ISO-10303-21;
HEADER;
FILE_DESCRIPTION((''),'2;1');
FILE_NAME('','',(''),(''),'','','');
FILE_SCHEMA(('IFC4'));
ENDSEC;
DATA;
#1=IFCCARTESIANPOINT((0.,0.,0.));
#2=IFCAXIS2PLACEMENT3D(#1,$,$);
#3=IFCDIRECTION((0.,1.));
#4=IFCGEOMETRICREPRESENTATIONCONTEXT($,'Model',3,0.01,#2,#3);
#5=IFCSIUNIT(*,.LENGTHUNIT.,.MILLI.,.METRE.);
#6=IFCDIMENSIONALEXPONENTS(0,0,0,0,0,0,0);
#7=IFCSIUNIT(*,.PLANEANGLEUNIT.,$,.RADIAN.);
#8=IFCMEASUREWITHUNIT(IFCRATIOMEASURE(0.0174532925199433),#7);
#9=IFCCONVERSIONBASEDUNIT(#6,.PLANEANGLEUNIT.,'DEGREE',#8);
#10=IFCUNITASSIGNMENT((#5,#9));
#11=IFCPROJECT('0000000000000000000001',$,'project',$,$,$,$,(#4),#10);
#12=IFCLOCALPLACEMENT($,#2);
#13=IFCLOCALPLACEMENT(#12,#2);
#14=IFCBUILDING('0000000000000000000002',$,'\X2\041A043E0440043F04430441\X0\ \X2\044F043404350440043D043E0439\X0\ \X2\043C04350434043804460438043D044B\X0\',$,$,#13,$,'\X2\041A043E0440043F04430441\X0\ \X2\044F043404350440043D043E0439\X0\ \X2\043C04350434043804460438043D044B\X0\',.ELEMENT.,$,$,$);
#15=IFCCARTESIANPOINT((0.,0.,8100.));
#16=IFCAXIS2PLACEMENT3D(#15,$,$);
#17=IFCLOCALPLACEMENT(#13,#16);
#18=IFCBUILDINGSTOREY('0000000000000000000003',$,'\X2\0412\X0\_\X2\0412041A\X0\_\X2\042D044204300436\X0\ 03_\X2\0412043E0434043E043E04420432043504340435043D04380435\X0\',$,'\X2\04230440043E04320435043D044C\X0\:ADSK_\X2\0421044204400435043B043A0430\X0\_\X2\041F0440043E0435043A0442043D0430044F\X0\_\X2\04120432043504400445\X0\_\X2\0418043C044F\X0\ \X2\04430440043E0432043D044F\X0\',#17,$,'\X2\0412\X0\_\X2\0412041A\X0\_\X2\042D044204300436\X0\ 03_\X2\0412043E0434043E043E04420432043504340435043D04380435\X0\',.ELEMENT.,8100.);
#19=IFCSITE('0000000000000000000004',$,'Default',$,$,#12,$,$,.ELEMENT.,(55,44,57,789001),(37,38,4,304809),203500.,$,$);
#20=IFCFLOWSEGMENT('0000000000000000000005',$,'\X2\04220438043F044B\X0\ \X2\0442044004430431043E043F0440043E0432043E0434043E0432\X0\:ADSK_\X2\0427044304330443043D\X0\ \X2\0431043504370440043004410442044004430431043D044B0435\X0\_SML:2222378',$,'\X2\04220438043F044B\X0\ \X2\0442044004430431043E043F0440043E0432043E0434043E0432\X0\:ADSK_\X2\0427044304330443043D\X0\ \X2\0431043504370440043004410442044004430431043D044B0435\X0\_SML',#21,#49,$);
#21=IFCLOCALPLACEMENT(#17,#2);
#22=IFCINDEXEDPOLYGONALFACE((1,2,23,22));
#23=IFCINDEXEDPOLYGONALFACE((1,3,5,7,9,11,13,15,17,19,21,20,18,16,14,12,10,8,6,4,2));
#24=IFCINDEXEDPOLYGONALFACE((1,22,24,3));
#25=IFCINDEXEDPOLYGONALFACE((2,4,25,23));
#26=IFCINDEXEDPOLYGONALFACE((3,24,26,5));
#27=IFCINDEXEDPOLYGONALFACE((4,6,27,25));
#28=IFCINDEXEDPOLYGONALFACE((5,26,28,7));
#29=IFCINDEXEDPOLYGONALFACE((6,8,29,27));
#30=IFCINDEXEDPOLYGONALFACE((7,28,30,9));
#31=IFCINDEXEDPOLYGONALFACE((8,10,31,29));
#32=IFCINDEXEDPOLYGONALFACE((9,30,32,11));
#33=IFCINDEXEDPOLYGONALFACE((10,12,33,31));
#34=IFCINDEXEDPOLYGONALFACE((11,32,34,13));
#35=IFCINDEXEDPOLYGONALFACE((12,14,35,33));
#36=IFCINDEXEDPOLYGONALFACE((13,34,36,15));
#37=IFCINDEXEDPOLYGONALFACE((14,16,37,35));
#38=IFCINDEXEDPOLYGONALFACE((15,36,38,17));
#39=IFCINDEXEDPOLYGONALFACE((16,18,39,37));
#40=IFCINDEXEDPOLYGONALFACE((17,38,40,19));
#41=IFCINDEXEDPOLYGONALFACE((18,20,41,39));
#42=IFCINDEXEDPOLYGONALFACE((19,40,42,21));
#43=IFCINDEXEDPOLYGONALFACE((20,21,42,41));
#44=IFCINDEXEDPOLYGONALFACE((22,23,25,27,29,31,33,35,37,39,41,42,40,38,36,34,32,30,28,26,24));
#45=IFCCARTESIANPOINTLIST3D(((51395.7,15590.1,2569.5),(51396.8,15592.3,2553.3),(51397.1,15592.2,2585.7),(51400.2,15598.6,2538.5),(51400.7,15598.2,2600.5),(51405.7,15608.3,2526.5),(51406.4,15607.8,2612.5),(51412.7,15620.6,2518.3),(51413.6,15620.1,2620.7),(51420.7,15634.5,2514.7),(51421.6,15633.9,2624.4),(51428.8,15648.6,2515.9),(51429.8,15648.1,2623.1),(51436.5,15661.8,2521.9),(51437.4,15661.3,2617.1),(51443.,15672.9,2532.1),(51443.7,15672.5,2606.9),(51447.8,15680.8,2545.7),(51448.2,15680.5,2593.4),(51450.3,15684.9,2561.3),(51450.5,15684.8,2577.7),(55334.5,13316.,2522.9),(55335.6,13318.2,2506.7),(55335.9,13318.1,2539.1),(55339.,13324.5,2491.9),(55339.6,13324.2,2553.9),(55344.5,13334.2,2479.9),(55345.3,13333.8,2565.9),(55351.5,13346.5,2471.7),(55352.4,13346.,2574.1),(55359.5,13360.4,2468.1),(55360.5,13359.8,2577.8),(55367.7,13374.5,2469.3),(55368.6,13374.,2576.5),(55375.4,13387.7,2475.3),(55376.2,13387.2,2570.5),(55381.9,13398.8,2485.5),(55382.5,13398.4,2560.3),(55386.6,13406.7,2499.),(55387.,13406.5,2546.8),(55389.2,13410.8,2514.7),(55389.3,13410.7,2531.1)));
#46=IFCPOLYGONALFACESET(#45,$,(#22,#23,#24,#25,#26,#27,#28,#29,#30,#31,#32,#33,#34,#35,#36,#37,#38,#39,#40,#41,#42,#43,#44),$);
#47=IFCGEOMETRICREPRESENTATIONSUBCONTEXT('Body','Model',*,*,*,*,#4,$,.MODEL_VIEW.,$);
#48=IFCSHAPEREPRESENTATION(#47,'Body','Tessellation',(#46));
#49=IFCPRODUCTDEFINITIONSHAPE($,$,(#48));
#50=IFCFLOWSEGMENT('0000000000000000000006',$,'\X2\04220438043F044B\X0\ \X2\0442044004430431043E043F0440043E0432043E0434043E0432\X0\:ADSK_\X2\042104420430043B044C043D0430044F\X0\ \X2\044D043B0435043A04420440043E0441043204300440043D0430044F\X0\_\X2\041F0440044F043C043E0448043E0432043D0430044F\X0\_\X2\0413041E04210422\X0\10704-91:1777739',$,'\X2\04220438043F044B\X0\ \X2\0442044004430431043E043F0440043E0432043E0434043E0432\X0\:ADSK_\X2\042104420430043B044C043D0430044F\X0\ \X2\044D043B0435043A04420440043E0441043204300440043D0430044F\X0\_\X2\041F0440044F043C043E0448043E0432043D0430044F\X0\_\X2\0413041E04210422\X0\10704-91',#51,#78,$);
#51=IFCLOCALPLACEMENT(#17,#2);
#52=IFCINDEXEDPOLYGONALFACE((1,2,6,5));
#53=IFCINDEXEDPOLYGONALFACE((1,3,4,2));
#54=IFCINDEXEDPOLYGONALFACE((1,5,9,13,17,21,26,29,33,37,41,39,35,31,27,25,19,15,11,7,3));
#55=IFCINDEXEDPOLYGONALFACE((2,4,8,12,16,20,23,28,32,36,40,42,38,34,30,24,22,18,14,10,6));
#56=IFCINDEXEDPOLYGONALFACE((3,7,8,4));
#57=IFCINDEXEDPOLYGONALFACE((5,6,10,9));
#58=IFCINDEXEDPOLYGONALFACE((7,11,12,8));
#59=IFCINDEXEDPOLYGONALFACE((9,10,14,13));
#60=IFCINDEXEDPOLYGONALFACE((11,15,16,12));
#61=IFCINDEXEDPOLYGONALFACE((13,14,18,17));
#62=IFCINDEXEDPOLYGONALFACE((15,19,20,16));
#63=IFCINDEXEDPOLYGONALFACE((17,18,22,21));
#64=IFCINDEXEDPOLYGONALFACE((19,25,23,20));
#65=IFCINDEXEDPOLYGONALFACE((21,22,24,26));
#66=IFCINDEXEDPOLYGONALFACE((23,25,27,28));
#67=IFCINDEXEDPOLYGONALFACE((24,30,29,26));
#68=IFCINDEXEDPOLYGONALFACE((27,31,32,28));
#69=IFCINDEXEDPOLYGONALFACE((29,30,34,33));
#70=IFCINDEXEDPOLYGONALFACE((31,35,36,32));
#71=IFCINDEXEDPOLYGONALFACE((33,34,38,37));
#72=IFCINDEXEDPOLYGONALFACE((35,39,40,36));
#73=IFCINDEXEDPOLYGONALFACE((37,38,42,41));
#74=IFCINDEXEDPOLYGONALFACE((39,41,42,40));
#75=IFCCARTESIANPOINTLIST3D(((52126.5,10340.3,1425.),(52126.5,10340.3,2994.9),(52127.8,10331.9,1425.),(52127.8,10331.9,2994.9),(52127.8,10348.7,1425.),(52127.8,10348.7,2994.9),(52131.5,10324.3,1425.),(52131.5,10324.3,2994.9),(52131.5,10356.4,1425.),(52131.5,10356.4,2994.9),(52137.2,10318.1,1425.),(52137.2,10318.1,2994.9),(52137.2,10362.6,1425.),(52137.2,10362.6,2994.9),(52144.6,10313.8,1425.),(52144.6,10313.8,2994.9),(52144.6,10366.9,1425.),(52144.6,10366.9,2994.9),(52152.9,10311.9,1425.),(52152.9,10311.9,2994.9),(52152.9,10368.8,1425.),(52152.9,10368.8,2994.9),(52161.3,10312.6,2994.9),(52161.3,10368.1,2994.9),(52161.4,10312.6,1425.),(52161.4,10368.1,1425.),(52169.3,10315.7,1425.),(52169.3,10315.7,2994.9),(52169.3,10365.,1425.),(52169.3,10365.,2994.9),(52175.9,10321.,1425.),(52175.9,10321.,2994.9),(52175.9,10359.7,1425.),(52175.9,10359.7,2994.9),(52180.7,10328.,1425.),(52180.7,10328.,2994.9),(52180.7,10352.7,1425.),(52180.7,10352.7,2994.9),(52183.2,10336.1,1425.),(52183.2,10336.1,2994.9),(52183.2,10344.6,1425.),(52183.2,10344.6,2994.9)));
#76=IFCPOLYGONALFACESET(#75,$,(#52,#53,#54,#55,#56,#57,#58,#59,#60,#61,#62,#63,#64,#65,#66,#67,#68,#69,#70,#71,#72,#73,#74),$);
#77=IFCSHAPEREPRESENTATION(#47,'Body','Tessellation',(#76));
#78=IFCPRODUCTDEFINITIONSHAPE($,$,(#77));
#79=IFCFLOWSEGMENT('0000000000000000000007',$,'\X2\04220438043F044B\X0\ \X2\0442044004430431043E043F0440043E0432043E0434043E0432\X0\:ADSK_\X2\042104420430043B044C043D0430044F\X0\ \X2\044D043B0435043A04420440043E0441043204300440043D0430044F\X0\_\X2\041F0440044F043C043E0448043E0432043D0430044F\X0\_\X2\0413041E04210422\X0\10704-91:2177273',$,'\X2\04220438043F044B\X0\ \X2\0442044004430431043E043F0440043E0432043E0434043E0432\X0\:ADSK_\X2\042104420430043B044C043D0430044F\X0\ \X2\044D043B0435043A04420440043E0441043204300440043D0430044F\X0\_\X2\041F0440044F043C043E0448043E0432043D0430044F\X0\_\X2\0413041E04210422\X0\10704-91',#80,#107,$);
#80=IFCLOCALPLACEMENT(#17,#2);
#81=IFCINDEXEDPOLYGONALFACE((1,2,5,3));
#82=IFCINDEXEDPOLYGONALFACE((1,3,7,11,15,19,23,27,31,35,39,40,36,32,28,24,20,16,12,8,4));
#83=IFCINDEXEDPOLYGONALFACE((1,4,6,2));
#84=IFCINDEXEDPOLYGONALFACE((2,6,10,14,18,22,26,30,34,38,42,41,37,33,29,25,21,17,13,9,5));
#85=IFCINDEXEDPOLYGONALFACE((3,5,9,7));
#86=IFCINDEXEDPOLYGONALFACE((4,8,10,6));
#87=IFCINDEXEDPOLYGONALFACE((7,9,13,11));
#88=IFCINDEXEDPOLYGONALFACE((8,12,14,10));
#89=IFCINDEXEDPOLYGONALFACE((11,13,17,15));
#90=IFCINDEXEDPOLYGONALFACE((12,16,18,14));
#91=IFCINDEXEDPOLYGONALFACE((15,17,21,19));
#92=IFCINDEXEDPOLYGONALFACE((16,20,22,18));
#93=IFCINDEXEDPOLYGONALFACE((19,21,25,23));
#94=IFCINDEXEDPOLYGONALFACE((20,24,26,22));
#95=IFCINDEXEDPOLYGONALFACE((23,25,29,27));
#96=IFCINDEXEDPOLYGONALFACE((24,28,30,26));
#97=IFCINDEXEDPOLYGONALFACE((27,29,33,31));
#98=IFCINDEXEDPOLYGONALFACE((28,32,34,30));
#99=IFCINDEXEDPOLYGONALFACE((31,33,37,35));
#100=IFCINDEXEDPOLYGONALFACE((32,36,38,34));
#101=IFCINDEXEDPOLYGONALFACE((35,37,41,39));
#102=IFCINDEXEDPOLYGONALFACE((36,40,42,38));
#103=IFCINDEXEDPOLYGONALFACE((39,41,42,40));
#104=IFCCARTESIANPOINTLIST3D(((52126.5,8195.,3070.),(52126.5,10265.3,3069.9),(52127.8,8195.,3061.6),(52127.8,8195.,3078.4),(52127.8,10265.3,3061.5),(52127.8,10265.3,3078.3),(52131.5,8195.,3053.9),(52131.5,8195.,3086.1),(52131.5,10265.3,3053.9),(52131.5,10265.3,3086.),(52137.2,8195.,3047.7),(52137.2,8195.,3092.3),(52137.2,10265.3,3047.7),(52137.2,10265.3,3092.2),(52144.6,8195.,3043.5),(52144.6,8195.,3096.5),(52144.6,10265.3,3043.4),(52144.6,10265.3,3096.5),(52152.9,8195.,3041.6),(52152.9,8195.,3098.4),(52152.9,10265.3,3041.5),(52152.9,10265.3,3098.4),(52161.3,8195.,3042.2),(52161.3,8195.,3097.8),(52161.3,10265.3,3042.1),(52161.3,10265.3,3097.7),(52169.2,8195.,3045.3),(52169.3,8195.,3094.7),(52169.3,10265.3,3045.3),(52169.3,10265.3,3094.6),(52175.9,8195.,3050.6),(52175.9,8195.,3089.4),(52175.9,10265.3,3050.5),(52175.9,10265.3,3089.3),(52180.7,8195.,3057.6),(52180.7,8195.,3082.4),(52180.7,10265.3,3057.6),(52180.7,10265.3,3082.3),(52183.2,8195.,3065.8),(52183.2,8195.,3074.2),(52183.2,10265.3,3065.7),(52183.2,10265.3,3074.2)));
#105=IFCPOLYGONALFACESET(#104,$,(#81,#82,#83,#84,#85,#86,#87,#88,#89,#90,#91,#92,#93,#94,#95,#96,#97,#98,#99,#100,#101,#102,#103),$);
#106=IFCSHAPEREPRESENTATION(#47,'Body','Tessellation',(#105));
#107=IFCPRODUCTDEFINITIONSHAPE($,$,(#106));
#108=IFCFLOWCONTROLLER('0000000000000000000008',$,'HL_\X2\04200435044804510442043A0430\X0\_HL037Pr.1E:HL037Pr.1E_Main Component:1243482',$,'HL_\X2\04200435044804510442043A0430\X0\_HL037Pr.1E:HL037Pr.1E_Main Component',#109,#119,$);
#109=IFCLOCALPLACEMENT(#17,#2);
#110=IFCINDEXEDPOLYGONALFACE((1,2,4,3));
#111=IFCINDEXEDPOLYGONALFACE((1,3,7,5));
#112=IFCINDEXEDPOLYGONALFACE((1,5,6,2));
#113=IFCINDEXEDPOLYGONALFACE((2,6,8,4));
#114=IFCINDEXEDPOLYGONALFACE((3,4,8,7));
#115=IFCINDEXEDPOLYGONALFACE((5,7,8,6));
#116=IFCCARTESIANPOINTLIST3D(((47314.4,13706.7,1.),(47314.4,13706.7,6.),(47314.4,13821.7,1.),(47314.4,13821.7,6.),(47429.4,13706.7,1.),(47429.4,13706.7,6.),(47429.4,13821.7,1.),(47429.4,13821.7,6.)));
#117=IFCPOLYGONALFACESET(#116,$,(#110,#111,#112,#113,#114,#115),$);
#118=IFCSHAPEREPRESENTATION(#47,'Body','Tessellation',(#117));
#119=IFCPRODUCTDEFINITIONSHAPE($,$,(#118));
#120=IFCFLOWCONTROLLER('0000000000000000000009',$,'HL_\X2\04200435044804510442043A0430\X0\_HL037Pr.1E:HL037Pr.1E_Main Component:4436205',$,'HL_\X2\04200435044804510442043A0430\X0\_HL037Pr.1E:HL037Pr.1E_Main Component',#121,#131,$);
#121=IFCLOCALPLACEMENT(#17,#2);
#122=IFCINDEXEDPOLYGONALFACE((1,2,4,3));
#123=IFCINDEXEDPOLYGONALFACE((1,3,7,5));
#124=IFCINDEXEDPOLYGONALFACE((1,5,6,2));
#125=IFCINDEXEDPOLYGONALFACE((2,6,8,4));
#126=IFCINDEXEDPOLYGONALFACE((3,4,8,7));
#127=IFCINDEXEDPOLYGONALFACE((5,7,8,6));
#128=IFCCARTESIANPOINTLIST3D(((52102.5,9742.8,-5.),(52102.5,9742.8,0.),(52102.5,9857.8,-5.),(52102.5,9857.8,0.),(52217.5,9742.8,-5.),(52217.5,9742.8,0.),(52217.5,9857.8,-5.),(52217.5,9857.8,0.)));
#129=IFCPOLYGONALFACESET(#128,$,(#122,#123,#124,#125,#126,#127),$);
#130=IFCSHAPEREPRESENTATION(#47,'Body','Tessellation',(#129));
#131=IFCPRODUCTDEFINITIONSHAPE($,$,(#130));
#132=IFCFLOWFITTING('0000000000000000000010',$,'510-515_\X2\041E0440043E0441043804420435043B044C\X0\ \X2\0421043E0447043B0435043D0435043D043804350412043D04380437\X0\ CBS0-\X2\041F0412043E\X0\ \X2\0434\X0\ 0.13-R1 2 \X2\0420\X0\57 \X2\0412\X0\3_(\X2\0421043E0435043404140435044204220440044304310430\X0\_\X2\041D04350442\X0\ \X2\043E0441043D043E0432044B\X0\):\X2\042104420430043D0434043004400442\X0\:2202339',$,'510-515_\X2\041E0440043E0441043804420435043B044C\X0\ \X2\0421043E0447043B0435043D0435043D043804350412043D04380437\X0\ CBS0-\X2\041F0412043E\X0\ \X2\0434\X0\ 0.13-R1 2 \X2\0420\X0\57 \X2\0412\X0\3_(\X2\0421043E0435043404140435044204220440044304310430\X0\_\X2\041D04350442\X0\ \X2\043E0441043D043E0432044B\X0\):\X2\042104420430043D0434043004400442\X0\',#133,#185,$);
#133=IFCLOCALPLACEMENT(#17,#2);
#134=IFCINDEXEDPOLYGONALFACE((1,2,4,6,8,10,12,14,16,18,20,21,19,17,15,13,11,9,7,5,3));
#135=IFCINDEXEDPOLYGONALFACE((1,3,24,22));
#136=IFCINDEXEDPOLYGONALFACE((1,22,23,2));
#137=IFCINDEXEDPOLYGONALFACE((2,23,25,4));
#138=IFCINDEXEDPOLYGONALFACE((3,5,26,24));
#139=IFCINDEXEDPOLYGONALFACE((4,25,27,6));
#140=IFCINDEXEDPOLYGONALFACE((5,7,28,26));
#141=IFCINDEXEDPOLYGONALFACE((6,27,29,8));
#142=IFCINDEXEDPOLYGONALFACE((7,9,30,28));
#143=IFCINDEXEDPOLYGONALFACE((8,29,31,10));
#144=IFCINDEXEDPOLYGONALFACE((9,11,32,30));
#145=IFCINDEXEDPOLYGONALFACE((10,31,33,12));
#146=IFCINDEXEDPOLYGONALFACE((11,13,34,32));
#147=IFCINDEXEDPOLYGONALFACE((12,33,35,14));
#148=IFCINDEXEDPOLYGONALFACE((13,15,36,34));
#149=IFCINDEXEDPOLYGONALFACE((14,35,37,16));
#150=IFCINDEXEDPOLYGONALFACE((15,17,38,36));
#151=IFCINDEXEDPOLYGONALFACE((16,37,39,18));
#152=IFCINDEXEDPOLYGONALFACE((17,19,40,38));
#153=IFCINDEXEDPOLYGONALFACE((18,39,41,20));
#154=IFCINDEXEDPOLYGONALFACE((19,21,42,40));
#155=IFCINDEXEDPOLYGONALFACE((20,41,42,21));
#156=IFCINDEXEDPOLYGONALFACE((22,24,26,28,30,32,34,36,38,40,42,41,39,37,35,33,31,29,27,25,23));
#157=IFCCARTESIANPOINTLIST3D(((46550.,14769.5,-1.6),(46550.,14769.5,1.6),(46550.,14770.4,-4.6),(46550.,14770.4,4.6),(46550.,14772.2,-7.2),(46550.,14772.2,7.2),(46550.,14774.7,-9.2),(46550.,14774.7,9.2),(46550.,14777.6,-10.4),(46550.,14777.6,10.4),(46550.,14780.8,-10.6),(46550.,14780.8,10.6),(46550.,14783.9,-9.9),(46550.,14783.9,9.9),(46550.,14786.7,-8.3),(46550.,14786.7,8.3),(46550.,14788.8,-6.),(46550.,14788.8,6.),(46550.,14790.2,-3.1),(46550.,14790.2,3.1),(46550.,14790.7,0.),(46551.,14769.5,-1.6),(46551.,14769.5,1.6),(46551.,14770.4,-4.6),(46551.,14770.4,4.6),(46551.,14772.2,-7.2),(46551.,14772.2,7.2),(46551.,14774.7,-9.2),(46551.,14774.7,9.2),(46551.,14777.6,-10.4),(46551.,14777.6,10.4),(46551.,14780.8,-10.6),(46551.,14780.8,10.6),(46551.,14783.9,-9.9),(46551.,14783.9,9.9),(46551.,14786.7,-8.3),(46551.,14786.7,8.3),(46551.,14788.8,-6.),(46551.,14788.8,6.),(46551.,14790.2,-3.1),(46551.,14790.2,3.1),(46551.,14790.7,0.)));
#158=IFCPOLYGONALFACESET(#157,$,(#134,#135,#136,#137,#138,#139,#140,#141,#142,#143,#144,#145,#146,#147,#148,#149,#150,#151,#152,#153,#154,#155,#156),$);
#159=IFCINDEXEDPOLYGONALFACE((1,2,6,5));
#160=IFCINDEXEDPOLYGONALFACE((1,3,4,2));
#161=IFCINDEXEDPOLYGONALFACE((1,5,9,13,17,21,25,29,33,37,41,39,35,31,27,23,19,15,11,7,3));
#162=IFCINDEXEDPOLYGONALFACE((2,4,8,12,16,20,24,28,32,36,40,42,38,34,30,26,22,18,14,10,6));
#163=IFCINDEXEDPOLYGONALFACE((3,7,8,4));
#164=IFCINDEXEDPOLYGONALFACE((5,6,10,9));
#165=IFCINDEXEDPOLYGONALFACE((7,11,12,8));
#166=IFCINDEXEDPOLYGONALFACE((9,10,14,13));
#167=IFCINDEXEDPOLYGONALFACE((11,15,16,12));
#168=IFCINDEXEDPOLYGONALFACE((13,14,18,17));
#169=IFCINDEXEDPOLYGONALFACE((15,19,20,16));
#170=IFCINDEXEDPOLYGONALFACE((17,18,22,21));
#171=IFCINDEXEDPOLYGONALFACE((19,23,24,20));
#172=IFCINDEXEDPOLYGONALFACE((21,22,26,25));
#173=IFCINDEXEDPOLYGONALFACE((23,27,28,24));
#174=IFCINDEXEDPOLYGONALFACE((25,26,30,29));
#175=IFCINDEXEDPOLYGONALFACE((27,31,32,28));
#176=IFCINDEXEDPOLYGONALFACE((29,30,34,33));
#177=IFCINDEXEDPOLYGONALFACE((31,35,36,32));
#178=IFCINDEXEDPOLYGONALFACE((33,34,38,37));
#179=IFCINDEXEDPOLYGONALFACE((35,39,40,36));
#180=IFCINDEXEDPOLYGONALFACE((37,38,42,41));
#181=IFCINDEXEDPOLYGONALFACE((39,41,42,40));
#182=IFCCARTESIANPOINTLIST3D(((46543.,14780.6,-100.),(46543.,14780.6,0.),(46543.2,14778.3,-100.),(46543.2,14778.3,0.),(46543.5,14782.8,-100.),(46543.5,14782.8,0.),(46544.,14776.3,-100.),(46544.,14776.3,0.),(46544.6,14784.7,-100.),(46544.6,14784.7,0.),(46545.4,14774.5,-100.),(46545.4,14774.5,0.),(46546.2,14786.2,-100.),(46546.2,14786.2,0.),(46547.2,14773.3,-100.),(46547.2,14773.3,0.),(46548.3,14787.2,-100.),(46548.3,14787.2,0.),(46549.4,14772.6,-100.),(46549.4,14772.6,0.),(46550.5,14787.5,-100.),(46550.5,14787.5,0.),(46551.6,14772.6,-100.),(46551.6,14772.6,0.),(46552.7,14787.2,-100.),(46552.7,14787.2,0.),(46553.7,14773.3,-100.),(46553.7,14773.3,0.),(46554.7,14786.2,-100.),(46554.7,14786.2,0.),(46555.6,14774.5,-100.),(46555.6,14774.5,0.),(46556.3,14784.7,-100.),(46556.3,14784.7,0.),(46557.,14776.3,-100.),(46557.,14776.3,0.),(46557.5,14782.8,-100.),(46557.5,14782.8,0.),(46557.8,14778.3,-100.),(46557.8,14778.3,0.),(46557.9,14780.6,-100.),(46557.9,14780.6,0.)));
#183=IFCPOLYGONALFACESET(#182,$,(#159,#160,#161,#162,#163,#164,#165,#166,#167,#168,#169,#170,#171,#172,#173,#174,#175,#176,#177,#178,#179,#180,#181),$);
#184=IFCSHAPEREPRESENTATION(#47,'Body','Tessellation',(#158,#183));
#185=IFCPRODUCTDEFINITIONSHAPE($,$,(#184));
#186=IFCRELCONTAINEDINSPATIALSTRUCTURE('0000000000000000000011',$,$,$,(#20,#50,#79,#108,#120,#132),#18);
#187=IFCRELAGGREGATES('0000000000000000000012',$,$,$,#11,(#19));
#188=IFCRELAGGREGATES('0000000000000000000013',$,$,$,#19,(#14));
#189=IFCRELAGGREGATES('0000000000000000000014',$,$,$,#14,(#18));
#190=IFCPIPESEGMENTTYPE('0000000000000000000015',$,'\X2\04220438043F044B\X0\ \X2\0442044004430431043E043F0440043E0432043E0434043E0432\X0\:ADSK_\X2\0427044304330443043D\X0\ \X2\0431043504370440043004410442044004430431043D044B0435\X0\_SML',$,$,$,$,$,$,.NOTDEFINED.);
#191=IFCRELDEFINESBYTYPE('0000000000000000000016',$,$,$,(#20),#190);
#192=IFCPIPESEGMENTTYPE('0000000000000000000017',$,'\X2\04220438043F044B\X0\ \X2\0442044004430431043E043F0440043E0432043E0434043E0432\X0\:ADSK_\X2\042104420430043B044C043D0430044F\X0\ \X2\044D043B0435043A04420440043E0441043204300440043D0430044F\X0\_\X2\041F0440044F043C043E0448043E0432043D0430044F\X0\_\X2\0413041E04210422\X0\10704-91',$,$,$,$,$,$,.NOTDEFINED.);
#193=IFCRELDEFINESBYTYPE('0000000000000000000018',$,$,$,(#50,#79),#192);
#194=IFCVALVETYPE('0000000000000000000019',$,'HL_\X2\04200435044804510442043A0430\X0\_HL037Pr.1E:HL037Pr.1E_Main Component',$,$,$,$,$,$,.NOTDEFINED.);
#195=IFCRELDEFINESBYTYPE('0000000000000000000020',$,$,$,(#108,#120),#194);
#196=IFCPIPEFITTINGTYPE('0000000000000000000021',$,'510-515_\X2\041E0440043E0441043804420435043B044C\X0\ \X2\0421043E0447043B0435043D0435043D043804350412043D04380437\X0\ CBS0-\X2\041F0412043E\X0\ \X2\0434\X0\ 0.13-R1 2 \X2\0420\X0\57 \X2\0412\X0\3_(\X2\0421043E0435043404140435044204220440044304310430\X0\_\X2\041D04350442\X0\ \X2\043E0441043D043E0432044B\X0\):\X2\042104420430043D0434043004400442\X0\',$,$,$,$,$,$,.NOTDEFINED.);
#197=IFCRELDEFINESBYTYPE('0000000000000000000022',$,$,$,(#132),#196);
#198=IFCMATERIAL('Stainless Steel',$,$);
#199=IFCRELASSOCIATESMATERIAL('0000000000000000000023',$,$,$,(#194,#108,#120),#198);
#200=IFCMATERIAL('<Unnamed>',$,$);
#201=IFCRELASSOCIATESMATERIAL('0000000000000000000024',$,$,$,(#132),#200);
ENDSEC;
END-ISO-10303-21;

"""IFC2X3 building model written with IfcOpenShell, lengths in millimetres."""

from ifc_helpers import new_model, entity, si_unit, converted_unit, direction, frame, origin, origin_2d_with_axis, place, context, subcontext, project, spatial, rectangle, circle, extrude, source, transform, mapped, material, type_object, type_shapes, element, save


model = new_model("IFC2X3")

# Units and contexts
model_context = context("Model", 3, precision=0.01, world=origin(), true_north=direction((0.0, 1.0)))
body_context = subcontext(model_context, "Body", "Model", "MODEL_VIEW")
ifc_project = project(units=[si_unit("LENGTHUNIT", "METRE", prefix="MILLI"), converted_unit("PLANEANGLEUNIT", "DEGREE", entity("IfcRatioMeasure", 0.0174532925199433), si_unit("PLANEANGLEUNIT", "RADIAN"), dimensions=[0, 0, 0, 0, 0, 0, 0])], contexts=[model_context])

# Site, building, storey
site_placement = place(None, origin())
site = spatial("IfcSite", under=ifc_project, at=site_placement, Name="Default", CompositionType="ELEMENT", RefLatitude=(55, 44, 57, 789001), RefLongitude=(37, 38, 4, 304809), RefElevation=203500.0)
building_placement = place(site_placement, origin())
building = spatial("IfcBuilding", under=site, at=building_placement, Name="Корпус ядерной медицины", LongName="Корпус ядерной медицины", CompositionType="ELEMENT")
storey_placement = place(building_placement, frame((0.0, 0.0, 8100.0)))
storey = spatial("IfcBuildingStorey", under=building, at=storey_placement, Name="В_ВК_Этаж 03_Водоотведение", ObjectType="Уровень:ADSK_Стрелка_Проектная_Вверх_Имя уровня", LongName="В_ВК_Этаж 03_Водоотведение", CompositionType="ELEMENT", Elevation=8100.0)

# Flow segments
pipe_segment_type_1 = type_object("IfcPipeSegmentType", Name="Типы трубопроводов:ADSK_Чугун безраструбные_SML", PredefinedType="NOTDEFINED")
flow_segment_1_placement = place(storey_placement, frame((51394.1, 13314.4, 2466.3)))
element("IfcFlowSegment", 1, at=flow_segment_1_placement, inside=storey, type_object=pipe_segment_type_1, Name="Типы трубопроводов:ADSK_Чугун безраструбные_SML:2222378", ObjectType="Типы трубопроводов:ADSK_Чугун безраструбные_SML", context=body_context, shape_type="SweptSolid", body=[
    extrude(circle(Radius=55.0, at=origin_2d_with_axis()), frame((3967.9, 49.2, 56.6), z_axis=(-0.865981, 0.499972, 0.010247), x_axis=(-0.499998, -0.866027, 0.0)), (0.0, 0.0, 1.0), 4548.4),
])
pipe_segment_type_2 = type_object("IfcPipeSegmentType", Name="Типы трубопроводов:ADSK_Стальная электросварная_Прямошовная_ГОСТ10704-91", PredefinedType="NOTDEFINED")
flow_segment_2_placement = place(storey_placement, frame((52124.9, 10310.2, 1425.0)))
element("IfcFlowSegment", 2, at=flow_segment_2_placement, inside=storey, type_object=pipe_segment_type_2, Name="Типы трубопроводов:ADSK_Стальная электросварная_Прямошовная_ГОСТ10704-91:1777739", ObjectType="Типы трубопроводов:ADSK_Стальная электросварная_Прямошовная_ГОСТ10704-91", context=body_context, shape_type="SweptSolid", body=[
    extrude(circle(Radius=28.5, at=origin_2d_with_axis()), frame((30.1, 30.1, 0.0), z_axis=(-0.000002, -0.000002, 1.0), x_axis=(-1.0, 0.0, -0.000002)), (0.0, 0.0, 1.0), 1569.9),
])
flow_segment_3_placement = place(storey_placement, frame((52124.9, 8195.0, 3039.8)))
element("IfcFlowSegment", 3, at=flow_segment_3_placement, inside=storey, type_object=pipe_segment_type_2, Name="Типы трубопроводов:ADSK_Стальная электросварная_Прямошовная_ГОСТ10704-91:2177273", ObjectType="Типы трубопроводов:ADSK_Стальная электросварная_Прямошовная_ГОСТ10704-91", context=body_context, shape_type="SweptSolid", body=[
    extrude(circle(Radius=28.5, at=origin_2d_with_axis()), frame((30.1, 0.0, 30.2), z_axis=(0.000001, 1.0, -0.000032), x_axis=(-1.0, 0.000001, 0.0)), (0.0, 0.0, 1.0), 2070.3),
])

# Flow controllers
ifc_material_1 = material(Name="Stainless Steel")
valve_type = type_object("IfcValveType", Name="HL_Решётка_HL037Pr.1E:HL037Pr.1E_Main Component", PredefinedType="NOTDEFINED", material=ifc_material_1)
shared_shape_1 = source(origin(), body_context, "Body", "SweptSolid", [
    extrude(rectangle(XDim=115.0, YDim=115.0, at=origin_2d_with_axis()), frame((0.0, 0.0, -5.0), z_axis=(0.0, 0.0, 1.0), x_axis=(0.0, -1.0, 0.0)), (0.0, 0.0, 1.0), 5.0),
])
type_shapes(valve_type, [shared_shape_1])
flow_controller_1_placement = place(storey_placement, frame((47371.8, 13764.2, 6.0), z_axis=(0.0, 0.0, 1.0), x_axis=(-1.0, 0.0, 0.0)))
element("IfcFlowController", 4, at=flow_controller_1_placement, inside=storey, type_object=valve_type, material=ifc_material_1, Name="HL_Решётка_HL037Pr.1E:HL037Pr.1E_Main Component:1243482", ObjectType="HL_Решётка_HL037Pr.1E:HL037Pr.1E_Main Component", context=body_context, shape_type="MappedRepresentation", body=[
    mapped(shared_shape_1, transform((0.0, 0.0, 0.0), scale=1.0)),
])
flow_controller_2_placement = place(storey_placement, frame((52160.0, 9800.3, 0.0), z_axis=(0.0, 0.0, 1.0), x_axis=(0.0, 1.0, 0.0)))
element("IfcFlowController", 5, at=flow_controller_2_placement, inside=storey, type_object=valve_type, material=ifc_material_1, Name="HL_Решётка_HL037Pr.1E:HL037Pr.1E_Main Component:4436205", ObjectType="HL_Решётка_HL037Pr.1E:HL037Pr.1E_Main Component", context=body_context, shape_type="MappedRepresentation", body=[
    mapped(shared_shape_1, transform((0.0, 0.0, 0.0), scale=1.0)),
])

# Flow fitting
ifc_material_2 = material(Name="<Unnamed>")
pipe_fitting_type = type_object("IfcPipeFittingType", Name="510-515_Ороситель СочленениеВниз CBS0-ПВо д 0.13-R1 2 Р57 В3_(СоедДетТруба_Нет основы):Стандарт", PredefinedType="NOTDEFINED")
shared_shape_2 = source(origin(), body_context, "Body", "SweptSolid", [
    extrude(circle(Radius=10.7, at=origin_2d_with_axis()), frame((-0.5, 0.0, 0.0), z_axis=(1.0, 0.0, 0.0), x_axis=(0.0, 1.0, 0.0)), (0.0, 0.0, 1.0), 1.0),
    extrude(circle(Radius=7.5, at=origin_2d_with_axis()), frame((0.0, 0.0, -100.0), z_axis=(0.0, 0.0, 1.0), x_axis=(0.0, 1.0, 0.0)), (0.0, 0.0, 1.0), 100.0),
])
type_shapes(pipe_fitting_type, [shared_shape_2])
for number, where, name in (
    (6, (46550.5, 14780.0, 0.0), "510-515_Ороситель СочленениеВниз CBS0-ПВо д 0.13-R1 2 Р57 В3_(СоедДетТруба_Нет основы):Стандарт:2202339"),
):
    element("IfcFlowFitting", number, at=place(storey_placement, frame(where)), inside=storey, type_object=pipe_fitting_type, material=ifc_material_2, Name=name, ObjectType="510-515_Ороситель СочленениеВниз CBS0-ПВо д 0.13-R1 2 Р57 В3_(СоедДетТруба_Нет основы):Стандарт", context=body_context, shape_type="MappedRepresentation", body=[
        mapped(shared_shape_2, transform((0.0, 0.0, 0.0), scale=1.0)),
    ])

save(model, "model.ifc")
